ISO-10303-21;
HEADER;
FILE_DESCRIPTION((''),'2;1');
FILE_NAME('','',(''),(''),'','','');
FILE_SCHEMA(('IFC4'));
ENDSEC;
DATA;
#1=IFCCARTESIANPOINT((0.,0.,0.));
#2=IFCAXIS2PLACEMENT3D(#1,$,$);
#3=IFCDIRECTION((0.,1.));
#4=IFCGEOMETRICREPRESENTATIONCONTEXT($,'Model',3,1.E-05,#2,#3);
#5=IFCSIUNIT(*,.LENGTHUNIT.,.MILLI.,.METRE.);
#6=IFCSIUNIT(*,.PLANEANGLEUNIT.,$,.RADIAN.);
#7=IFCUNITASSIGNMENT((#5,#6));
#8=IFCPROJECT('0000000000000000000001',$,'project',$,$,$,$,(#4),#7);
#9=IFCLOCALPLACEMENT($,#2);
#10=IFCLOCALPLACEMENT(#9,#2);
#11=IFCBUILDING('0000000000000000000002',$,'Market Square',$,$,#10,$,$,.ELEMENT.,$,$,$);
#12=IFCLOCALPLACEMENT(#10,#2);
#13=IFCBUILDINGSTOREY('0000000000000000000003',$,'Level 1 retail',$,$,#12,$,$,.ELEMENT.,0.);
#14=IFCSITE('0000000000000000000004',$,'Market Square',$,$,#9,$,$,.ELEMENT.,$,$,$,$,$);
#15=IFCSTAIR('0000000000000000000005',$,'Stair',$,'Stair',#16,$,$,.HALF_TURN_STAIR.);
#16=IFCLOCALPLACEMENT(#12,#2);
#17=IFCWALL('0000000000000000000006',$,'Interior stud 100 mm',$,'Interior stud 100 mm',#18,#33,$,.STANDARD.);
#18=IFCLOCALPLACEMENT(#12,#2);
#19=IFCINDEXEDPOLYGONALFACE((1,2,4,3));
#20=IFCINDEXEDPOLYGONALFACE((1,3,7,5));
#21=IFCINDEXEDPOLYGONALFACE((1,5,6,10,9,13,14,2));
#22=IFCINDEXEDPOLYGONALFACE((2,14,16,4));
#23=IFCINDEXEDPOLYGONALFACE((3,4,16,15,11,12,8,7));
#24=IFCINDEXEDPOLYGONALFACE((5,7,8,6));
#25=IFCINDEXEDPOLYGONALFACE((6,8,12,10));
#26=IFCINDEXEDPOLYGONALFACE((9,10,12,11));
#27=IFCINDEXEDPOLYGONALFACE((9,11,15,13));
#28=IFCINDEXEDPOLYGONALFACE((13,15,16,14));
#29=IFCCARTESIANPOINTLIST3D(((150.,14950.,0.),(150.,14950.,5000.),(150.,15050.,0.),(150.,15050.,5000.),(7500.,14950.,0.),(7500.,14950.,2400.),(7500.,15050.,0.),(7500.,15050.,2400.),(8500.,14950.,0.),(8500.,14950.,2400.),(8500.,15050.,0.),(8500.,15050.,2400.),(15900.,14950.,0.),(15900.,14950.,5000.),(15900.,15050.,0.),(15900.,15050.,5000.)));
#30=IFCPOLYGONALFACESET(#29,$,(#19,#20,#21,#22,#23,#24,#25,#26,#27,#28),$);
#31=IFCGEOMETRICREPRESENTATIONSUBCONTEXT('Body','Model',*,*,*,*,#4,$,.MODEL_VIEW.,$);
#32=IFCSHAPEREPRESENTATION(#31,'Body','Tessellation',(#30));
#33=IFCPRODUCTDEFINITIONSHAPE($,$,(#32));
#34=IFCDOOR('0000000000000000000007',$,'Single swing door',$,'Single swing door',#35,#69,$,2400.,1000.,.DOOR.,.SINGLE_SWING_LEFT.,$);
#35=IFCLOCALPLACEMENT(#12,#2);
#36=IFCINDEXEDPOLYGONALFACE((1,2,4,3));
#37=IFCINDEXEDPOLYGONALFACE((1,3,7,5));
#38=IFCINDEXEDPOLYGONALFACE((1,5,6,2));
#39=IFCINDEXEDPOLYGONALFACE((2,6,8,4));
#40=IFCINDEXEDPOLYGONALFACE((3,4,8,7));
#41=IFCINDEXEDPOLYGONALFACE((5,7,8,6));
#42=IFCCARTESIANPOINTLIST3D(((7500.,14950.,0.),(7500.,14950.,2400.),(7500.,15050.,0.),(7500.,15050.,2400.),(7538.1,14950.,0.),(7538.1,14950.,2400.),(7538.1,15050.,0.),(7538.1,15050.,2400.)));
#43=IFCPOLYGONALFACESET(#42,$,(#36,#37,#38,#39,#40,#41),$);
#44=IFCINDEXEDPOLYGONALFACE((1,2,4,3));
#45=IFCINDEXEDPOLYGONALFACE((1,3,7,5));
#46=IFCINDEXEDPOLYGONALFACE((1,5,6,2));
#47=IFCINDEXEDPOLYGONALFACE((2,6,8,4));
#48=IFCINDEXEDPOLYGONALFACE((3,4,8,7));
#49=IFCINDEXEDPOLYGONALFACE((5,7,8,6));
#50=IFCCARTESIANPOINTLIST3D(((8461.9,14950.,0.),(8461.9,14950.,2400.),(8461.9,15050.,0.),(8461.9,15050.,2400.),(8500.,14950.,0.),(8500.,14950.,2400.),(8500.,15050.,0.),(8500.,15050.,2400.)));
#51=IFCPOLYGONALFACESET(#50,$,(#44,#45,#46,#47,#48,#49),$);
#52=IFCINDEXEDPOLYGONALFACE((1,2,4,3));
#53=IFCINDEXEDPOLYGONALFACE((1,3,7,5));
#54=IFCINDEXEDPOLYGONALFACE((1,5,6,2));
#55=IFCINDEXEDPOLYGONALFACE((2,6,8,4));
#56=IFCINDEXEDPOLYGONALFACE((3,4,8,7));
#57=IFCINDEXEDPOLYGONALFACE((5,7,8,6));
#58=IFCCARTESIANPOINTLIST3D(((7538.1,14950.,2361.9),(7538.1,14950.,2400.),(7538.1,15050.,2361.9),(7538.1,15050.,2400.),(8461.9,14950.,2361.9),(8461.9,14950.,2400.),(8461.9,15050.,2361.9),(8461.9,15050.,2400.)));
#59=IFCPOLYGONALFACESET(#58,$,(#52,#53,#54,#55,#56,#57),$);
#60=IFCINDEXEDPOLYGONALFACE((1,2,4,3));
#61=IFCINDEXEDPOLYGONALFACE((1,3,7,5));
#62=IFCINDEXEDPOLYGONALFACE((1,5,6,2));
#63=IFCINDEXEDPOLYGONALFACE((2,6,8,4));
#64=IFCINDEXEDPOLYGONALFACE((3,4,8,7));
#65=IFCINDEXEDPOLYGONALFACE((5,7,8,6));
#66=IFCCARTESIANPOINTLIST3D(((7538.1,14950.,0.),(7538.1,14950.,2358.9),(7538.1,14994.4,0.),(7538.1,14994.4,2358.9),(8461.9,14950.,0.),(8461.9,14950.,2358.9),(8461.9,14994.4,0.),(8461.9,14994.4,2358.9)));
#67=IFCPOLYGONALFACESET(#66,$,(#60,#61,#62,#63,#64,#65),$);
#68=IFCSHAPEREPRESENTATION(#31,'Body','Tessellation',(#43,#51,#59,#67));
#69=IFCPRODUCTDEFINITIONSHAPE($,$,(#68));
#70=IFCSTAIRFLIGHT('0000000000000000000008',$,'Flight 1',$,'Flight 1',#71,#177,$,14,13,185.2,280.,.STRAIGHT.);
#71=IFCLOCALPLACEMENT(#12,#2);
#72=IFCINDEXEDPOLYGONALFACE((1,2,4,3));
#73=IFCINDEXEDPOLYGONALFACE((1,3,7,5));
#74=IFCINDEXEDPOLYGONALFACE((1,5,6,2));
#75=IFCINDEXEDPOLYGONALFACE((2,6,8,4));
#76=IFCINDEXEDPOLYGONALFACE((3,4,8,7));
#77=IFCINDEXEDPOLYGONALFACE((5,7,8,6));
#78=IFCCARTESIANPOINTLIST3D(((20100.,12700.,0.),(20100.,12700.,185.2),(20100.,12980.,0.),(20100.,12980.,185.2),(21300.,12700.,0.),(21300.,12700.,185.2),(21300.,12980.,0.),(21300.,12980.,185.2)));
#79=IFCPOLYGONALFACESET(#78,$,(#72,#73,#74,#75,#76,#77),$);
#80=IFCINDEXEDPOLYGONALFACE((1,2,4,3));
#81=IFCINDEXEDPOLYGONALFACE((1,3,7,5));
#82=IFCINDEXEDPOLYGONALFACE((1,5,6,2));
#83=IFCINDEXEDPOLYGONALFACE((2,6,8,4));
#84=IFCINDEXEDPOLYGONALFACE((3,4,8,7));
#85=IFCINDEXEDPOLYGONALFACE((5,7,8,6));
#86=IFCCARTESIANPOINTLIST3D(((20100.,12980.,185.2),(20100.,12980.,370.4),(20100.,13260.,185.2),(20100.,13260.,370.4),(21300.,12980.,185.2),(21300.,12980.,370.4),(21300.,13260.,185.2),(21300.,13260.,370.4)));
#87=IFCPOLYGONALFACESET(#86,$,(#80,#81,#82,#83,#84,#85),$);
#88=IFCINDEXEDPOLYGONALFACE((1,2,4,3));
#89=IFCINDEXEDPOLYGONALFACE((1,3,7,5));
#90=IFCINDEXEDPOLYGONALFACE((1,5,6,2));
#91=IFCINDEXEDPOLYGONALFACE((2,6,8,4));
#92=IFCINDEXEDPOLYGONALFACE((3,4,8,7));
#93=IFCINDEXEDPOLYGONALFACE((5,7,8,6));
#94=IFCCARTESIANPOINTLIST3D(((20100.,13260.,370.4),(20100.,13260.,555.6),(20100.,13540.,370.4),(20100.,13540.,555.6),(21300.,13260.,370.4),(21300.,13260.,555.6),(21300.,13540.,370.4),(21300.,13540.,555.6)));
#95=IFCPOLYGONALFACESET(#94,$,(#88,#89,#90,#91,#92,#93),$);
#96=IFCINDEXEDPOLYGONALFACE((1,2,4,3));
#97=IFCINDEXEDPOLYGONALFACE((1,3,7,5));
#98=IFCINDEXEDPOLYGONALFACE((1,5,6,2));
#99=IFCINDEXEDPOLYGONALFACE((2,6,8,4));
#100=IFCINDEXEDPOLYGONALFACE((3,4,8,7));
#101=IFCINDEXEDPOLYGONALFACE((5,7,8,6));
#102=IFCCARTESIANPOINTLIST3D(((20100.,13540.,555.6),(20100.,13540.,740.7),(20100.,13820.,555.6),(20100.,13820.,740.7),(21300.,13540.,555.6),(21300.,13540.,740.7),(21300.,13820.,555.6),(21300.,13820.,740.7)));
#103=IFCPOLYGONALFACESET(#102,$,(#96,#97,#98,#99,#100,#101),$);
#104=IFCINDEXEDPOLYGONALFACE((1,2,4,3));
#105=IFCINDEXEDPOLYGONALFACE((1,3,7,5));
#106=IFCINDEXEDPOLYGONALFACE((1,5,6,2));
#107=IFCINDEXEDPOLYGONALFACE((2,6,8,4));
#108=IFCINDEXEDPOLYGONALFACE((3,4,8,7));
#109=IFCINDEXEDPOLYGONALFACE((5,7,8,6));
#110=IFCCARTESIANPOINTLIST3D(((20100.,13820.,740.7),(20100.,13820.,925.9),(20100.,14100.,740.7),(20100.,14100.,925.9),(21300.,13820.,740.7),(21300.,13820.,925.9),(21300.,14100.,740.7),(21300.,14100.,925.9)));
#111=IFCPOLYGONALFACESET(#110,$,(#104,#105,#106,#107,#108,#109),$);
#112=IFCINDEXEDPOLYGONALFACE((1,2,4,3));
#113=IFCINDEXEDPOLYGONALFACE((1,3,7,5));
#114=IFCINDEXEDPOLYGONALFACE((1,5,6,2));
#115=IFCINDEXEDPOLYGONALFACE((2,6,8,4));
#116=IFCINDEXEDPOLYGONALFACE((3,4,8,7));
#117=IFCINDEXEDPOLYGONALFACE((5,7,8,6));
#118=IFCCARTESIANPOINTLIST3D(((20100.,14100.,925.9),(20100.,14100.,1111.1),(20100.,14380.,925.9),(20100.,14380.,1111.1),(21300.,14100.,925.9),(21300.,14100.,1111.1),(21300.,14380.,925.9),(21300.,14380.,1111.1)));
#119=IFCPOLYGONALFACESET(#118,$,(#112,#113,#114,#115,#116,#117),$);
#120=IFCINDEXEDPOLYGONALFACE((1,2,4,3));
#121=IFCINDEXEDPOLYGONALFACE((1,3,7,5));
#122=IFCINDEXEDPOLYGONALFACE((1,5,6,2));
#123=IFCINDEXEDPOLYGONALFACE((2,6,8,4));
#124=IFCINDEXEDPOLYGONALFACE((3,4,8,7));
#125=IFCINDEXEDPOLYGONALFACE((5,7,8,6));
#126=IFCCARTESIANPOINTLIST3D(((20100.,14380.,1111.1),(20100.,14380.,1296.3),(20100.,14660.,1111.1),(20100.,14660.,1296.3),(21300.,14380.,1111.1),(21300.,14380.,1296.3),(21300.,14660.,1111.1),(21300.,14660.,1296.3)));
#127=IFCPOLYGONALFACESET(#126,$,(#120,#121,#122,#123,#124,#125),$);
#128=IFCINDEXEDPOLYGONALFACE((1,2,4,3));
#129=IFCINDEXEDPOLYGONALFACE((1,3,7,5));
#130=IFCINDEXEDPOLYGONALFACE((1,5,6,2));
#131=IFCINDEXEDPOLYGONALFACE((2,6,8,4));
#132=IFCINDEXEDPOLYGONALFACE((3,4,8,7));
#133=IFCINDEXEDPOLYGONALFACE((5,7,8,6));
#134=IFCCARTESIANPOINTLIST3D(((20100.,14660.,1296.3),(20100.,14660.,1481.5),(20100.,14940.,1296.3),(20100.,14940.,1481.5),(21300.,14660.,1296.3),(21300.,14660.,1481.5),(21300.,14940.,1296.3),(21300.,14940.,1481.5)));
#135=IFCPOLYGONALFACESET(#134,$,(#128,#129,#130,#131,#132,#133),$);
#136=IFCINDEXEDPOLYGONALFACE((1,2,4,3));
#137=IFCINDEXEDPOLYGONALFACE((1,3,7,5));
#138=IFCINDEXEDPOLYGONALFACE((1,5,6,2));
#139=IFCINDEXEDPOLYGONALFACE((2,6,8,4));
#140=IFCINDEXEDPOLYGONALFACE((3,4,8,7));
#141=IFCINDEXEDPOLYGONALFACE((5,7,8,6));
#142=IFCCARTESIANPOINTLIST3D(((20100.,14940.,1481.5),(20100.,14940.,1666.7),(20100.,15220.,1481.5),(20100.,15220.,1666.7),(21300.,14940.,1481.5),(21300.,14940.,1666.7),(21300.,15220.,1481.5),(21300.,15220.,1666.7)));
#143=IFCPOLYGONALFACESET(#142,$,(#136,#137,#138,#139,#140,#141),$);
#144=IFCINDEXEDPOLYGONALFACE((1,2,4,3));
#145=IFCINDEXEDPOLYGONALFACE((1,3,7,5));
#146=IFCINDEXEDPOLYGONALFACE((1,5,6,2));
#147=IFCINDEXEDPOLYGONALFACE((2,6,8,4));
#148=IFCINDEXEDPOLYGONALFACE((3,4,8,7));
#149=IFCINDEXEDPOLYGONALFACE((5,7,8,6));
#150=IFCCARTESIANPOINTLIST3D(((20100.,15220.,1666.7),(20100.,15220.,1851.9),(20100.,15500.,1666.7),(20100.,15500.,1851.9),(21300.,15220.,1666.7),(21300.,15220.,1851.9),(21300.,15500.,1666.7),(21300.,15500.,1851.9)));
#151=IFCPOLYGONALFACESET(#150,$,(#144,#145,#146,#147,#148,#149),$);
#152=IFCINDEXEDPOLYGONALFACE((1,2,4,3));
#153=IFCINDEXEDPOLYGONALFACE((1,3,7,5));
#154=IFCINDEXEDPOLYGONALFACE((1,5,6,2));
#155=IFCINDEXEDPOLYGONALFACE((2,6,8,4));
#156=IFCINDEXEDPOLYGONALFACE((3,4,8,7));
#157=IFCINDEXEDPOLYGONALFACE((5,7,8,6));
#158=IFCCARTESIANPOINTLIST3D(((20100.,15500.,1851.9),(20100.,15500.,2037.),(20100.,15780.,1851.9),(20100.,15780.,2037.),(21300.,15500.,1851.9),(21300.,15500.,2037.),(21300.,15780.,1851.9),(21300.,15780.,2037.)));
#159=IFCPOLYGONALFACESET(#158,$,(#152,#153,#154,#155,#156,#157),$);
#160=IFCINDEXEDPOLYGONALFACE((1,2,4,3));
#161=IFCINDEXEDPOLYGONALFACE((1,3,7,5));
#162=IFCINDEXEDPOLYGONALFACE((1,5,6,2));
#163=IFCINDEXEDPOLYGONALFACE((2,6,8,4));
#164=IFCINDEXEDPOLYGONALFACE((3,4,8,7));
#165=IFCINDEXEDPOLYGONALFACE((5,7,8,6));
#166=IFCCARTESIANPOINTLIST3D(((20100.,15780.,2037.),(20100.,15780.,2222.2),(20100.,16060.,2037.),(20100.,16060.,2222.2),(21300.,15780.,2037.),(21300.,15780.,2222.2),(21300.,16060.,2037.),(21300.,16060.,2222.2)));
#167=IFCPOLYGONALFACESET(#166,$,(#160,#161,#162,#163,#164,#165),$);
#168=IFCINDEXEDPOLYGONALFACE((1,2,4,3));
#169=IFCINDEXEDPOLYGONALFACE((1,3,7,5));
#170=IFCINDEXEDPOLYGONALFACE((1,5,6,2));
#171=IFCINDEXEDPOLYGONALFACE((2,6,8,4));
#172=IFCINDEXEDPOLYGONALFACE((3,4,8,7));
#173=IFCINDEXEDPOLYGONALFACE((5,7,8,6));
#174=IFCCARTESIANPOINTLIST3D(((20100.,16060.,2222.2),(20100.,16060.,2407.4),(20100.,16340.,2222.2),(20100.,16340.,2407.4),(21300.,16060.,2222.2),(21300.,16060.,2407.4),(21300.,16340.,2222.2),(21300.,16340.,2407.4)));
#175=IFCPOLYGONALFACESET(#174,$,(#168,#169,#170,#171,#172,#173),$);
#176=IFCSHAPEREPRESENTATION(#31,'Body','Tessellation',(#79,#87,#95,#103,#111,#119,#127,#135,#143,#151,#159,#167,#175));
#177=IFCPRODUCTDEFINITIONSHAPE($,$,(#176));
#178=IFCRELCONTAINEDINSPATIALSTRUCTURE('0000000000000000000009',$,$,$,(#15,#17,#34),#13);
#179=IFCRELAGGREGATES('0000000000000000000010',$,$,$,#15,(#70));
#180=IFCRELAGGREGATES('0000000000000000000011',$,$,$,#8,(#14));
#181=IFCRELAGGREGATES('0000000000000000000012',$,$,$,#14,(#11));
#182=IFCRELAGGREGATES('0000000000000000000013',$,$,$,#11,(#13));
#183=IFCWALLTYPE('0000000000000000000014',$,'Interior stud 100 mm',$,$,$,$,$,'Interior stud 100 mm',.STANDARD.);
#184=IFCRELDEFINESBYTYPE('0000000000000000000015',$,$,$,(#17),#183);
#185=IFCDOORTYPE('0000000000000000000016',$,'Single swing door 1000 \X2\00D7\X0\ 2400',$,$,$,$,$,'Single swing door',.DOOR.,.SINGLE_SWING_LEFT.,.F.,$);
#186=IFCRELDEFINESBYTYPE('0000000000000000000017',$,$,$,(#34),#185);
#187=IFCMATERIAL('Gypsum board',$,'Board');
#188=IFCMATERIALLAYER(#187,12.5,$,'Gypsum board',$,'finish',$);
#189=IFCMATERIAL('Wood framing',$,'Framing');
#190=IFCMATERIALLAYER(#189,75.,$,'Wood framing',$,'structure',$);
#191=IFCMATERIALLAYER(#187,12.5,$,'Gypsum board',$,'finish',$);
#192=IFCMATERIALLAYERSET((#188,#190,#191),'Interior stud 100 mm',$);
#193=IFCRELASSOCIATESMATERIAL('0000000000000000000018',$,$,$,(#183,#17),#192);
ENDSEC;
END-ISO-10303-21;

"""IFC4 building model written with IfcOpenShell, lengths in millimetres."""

from ifc_helpers import new_model, si_unit, direction, frame, origin, origin_with_axes, place, context, subcontext, project, spatial, polyline, outline, extrude, material, layer, layer_set, layer_usage, type_object, element, fill, aggregate, save


model = new_model("IFC4")

# Units and contexts
model_context = context("Model", 3, precision=1e-05, world=origin(), true_north=direction((0.0, 1.0)))
body_context = subcontext(model_context, "Body", "Model", "MODEL_VIEW")
ifc_project = project(units=[si_unit("LENGTHUNIT", "METRE", prefix="MILLI"), si_unit("PLANEANGLEUNIT", "RADIAN")], contexts=[model_context])

# Site, building, storey
site_placement = place(None, origin())
site = spatial("IfcSite", under=ifc_project, at=site_placement, Name="Market Square", CompositionType="ELEMENT")
building_placement = place(site_placement, origin())
building = spatial("IfcBuilding", under=site, at=building_placement, Name="Market Square", CompositionType="ELEMENT")
storey_placement = place(building_placement, origin())
storey = spatial("IfcBuildingStorey", under=building, at=storey_placement, Name="Level 1 retail", CompositionType="ELEMENT", Elevation=0.0)

# Stair
stair_placement = place(storey_placement, origin_with_axes())
stair = element("IfcStair", 1, at=stair_placement, inside=storey, Name="Stair", ObjectType="Stair", PredefinedType="HALF_TURN_STAIR")

# Wall, opening, door
ifc_material_1 = material(Name="Gypsum board", Category="Board")
ifc_layer_1 = layer(ifc_material_1, 12.5, Name="Gypsum board", Category="finish")
ifc_material_2 = material(Name="Wood framing", Category="Framing")
ifc_layer_2 = layer(ifc_material_2, 75.0, Name="Wood framing", Category="structure")
ifc_layer_3 = layer(ifc_material_1, 12.5, Name="Gypsum board", Category="finish")
ifc_layer_set_1 = layer_set([ifc_layer_1, ifc_layer_2, ifc_layer_3], Name="Interior stud 100 mm")
ifc_layer_usage_1 = layer_usage(ifc_layer_set_1, "AXIS2", "NEGATIVE", 50.0)
wall_type_1 = type_object("IfcWallType", Name="Interior stud 100 mm", ElementType="Interior stud 100 mm", PredefinedType="STANDARD", material=ifc_layer_set_1)
wall_1_placement = place(storey_placement, frame((0.0, 15000.0, 0.0), z_axis=(0.0, 0.0, 1.0), x_axis=(1.0, 0.0, 0.0)))
wall_1 = element("IfcWall", 2, at=wall_1_placement, inside=storey, type_object=wall_type_1, material=ifc_layer_usage_1, Name="Interior stud 100 mm", ObjectType="Interior stud 100 mm", PredefinedType="STANDARD", context=body_context, shape_type="SweptSolid", body=[
    extrude(outline(polyline([(150.0, -50.0), (15900.0, -50.0), (15900.0, 50.0), (150.0, 50.0), (150.0, -50.0)])), origin(), (0.0, 0.0, 1.0), 5000.0),
])
opening_1_placement = place(wall_1_placement, frame((7500.0, 0.0, 0.0), z_axis=(0.0, 0.0, 1.0), x_axis=(1.0, 0.0, 0.0)))
opening_1 = element("IfcOpeningElement", 3, at=opening_1_placement, cuts=wall_1, PredefinedType="OPENING", context=body_context, shape_type="SweptSolid", body=[
    extrude(outline(polyline([(0.0, -60.0), (1000.0, -60.0), (1000.0, 60.0), (0.0, 60.0), (0.0, -60.0)])), origin(), (0.0, 0.0, 1.0), 2400.0),
])
door_type = type_object("IfcDoorType", Name="Single swing door 1000 × 2400", ElementType="Single swing door", OperationType="SINGLE_SWING_LEFT", ParameterTakesPrecedence=False, PredefinedType="DOOR")
door_placement = place(opening_1_placement, origin_with_axes())
door = element("IfcDoor", 4, at=door_placement, inside=storey, type_object=door_type, Name="Single swing door", ObjectType="Single swing door", OperationType="SINGLE_SWING_LEFT", OverallHeight=2400.0, OverallWidth=1000.0, PredefinedType="DOOR", context=body_context, shape_type="SweptSolid", body=[
    extrude(outline(polyline([(0.0, -50.0), (38.1, -50.0), (38.1, 50.0), (0.0, 50.0), (0.0, -50.0)])), origin(), (0.0, 0.0, 1.0), 2400.0),
    extrude(outline(polyline([(961.9, -50.0), (1000.0, -50.0), (1000.0, 50.0), (961.9, 50.0), (961.9, -50.0)])), origin(), (0.0, 0.0, 1.0), 2400.0),
    extrude(outline(polyline([(38.1, -50.0), (961.9, -50.0), (961.9, 50.0), (38.1, 50.0), (38.1, -50.0)])), frame((0.0, 0.0, 2361.9)), (0.0, 0.0, 1.0), 38.1),
    extrude(outline(polyline([(38.1, -50.0), (961.9, -50.0), (961.9, -5.5), (38.1, -5.5), (38.1, -50.0)])), origin(), (0.0, 0.0, 1.0), 2358.9),
])
fill(opening_1, door)

# Stair flight
stair_flight_placement = place(storey_placement, origin_with_axes())
stair_flight = element("IfcStairFlight", 5, at=stair_flight_placement, Name="Flight 1", ObjectType="Flight 1", NumberOfRisers=14, NumberOfTreads=13, PredefinedType="STRAIGHT", RiserHeight=185.2, TreadLength=280.0, context=body_context, shape_type="SweptSolid", body=[
    extrude(outline(polyline([(21300.0, 12700.0), (21300.0, 12980.0), (20100.0, 12980.0), (20100.0, 12700.0), (21300.0, 12700.0)])), origin(), (0.0, 0.0, 1.0), 185.2),
    extrude(outline(polyline([(21300.0, 12980.0), (21300.0, 13260.0), (20100.0, 13260.0), (20100.0, 12980.0), (21300.0, 12980.0)])), frame((0.0, 0.0, 185.2)), (0.0, 0.0, 1.0), 185.2),
    extrude(outline(polyline([(21300.0, 13260.0), (21300.0, 13540.0), (20100.0, 13540.0), (20100.0, 13260.0), (21300.0, 13260.0)])), frame((0.0, 0.0, 370.4)), (0.0, 0.0, 1.0), 185.2),
    extrude(outline(polyline([(21300.0, 13540.0), (21300.0, 13820.0), (20100.0, 13820.0), (20100.0, 13540.0), (21300.0, 13540.0)])), frame((0.0, 0.0, 555.6)), (0.0, 0.0, 1.0), 185.2),
    extrude(outline(polyline([(21300.0, 13820.0), (21300.0, 14100.0), (20100.0, 14100.0), (20100.0, 13820.0), (21300.0, 13820.0)])), frame((0.0, 0.0, 740.7)), (0.0, 0.0, 1.0), 185.2),
    extrude(outline(polyline([(21300.0, 14100.0), (21300.0, 14380.0), (20100.0, 14380.0), (20100.0, 14100.0), (21300.0, 14100.0)])), frame((0.0, 0.0, 925.9)), (0.0, 0.0, 1.0), 185.2),
    extrude(outline(polyline([(21300.0, 14380.0), (21300.0, 14660.0), (20100.0, 14660.0), (20100.0, 14380.0), (21300.0, 14380.0)])), frame((0.0, 0.0, 1111.1)), (0.0, 0.0, 1.0), 185.2),
    extrude(outline(polyline([(21300.0, 14660.0), (21300.0, 14940.0), (20100.0, 14940.0), (20100.0, 14660.0), (21300.0, 14660.0)])), frame((0.0, 0.0, 1296.3)), (0.0, 0.0, 1.0), 185.2),
    extrude(outline(polyline([(21300.0, 14940.0), (21300.0, 15220.0), (20100.0, 15220.0), (20100.0, 14940.0), (21300.0, 14940.0)])), frame((0.0, 0.0, 1481.5)), (0.0, 0.0, 1.0), 185.2),
    extrude(outline(polyline([(21300.0, 15220.0), (21300.0, 15500.0), (20100.0, 15500.0), (20100.0, 15220.0), (21300.0, 15220.0)])), frame((0.0, 0.0, 1666.7)), (0.0, 0.0, 1.0), 185.2),
    extrude(outline(polyline([(21300.0, 15500.0), (21300.0, 15780.0), (20100.0, 15780.0), (20100.0, 15500.0), (21300.0, 15500.0)])), frame((0.0, 0.0, 1851.9)), (0.0, 0.0, 1.0), 185.2),
    extrude(outline(polyline([(21300.0, 15780.0), (21300.0, 16060.0), (20100.0, 16060.0), (20100.0, 15780.0), (21300.0, 15780.0)])), frame((0.0, 0.0, 2037.0)), (0.0, 0.0, 1.0), 185.2),
    extrude(outline(polyline([(21300.0, 16060.0), (21300.0, 16340.0), (20100.0, 16340.0), (20100.0, 16060.0), (21300.0, 16060.0)])), frame((0.0, 0.0, 2222.2)), (0.0, 0.0, 1.0), 185.2),
])
aggregate(stair, [stair_flight])

save(model, "model.ifc")
